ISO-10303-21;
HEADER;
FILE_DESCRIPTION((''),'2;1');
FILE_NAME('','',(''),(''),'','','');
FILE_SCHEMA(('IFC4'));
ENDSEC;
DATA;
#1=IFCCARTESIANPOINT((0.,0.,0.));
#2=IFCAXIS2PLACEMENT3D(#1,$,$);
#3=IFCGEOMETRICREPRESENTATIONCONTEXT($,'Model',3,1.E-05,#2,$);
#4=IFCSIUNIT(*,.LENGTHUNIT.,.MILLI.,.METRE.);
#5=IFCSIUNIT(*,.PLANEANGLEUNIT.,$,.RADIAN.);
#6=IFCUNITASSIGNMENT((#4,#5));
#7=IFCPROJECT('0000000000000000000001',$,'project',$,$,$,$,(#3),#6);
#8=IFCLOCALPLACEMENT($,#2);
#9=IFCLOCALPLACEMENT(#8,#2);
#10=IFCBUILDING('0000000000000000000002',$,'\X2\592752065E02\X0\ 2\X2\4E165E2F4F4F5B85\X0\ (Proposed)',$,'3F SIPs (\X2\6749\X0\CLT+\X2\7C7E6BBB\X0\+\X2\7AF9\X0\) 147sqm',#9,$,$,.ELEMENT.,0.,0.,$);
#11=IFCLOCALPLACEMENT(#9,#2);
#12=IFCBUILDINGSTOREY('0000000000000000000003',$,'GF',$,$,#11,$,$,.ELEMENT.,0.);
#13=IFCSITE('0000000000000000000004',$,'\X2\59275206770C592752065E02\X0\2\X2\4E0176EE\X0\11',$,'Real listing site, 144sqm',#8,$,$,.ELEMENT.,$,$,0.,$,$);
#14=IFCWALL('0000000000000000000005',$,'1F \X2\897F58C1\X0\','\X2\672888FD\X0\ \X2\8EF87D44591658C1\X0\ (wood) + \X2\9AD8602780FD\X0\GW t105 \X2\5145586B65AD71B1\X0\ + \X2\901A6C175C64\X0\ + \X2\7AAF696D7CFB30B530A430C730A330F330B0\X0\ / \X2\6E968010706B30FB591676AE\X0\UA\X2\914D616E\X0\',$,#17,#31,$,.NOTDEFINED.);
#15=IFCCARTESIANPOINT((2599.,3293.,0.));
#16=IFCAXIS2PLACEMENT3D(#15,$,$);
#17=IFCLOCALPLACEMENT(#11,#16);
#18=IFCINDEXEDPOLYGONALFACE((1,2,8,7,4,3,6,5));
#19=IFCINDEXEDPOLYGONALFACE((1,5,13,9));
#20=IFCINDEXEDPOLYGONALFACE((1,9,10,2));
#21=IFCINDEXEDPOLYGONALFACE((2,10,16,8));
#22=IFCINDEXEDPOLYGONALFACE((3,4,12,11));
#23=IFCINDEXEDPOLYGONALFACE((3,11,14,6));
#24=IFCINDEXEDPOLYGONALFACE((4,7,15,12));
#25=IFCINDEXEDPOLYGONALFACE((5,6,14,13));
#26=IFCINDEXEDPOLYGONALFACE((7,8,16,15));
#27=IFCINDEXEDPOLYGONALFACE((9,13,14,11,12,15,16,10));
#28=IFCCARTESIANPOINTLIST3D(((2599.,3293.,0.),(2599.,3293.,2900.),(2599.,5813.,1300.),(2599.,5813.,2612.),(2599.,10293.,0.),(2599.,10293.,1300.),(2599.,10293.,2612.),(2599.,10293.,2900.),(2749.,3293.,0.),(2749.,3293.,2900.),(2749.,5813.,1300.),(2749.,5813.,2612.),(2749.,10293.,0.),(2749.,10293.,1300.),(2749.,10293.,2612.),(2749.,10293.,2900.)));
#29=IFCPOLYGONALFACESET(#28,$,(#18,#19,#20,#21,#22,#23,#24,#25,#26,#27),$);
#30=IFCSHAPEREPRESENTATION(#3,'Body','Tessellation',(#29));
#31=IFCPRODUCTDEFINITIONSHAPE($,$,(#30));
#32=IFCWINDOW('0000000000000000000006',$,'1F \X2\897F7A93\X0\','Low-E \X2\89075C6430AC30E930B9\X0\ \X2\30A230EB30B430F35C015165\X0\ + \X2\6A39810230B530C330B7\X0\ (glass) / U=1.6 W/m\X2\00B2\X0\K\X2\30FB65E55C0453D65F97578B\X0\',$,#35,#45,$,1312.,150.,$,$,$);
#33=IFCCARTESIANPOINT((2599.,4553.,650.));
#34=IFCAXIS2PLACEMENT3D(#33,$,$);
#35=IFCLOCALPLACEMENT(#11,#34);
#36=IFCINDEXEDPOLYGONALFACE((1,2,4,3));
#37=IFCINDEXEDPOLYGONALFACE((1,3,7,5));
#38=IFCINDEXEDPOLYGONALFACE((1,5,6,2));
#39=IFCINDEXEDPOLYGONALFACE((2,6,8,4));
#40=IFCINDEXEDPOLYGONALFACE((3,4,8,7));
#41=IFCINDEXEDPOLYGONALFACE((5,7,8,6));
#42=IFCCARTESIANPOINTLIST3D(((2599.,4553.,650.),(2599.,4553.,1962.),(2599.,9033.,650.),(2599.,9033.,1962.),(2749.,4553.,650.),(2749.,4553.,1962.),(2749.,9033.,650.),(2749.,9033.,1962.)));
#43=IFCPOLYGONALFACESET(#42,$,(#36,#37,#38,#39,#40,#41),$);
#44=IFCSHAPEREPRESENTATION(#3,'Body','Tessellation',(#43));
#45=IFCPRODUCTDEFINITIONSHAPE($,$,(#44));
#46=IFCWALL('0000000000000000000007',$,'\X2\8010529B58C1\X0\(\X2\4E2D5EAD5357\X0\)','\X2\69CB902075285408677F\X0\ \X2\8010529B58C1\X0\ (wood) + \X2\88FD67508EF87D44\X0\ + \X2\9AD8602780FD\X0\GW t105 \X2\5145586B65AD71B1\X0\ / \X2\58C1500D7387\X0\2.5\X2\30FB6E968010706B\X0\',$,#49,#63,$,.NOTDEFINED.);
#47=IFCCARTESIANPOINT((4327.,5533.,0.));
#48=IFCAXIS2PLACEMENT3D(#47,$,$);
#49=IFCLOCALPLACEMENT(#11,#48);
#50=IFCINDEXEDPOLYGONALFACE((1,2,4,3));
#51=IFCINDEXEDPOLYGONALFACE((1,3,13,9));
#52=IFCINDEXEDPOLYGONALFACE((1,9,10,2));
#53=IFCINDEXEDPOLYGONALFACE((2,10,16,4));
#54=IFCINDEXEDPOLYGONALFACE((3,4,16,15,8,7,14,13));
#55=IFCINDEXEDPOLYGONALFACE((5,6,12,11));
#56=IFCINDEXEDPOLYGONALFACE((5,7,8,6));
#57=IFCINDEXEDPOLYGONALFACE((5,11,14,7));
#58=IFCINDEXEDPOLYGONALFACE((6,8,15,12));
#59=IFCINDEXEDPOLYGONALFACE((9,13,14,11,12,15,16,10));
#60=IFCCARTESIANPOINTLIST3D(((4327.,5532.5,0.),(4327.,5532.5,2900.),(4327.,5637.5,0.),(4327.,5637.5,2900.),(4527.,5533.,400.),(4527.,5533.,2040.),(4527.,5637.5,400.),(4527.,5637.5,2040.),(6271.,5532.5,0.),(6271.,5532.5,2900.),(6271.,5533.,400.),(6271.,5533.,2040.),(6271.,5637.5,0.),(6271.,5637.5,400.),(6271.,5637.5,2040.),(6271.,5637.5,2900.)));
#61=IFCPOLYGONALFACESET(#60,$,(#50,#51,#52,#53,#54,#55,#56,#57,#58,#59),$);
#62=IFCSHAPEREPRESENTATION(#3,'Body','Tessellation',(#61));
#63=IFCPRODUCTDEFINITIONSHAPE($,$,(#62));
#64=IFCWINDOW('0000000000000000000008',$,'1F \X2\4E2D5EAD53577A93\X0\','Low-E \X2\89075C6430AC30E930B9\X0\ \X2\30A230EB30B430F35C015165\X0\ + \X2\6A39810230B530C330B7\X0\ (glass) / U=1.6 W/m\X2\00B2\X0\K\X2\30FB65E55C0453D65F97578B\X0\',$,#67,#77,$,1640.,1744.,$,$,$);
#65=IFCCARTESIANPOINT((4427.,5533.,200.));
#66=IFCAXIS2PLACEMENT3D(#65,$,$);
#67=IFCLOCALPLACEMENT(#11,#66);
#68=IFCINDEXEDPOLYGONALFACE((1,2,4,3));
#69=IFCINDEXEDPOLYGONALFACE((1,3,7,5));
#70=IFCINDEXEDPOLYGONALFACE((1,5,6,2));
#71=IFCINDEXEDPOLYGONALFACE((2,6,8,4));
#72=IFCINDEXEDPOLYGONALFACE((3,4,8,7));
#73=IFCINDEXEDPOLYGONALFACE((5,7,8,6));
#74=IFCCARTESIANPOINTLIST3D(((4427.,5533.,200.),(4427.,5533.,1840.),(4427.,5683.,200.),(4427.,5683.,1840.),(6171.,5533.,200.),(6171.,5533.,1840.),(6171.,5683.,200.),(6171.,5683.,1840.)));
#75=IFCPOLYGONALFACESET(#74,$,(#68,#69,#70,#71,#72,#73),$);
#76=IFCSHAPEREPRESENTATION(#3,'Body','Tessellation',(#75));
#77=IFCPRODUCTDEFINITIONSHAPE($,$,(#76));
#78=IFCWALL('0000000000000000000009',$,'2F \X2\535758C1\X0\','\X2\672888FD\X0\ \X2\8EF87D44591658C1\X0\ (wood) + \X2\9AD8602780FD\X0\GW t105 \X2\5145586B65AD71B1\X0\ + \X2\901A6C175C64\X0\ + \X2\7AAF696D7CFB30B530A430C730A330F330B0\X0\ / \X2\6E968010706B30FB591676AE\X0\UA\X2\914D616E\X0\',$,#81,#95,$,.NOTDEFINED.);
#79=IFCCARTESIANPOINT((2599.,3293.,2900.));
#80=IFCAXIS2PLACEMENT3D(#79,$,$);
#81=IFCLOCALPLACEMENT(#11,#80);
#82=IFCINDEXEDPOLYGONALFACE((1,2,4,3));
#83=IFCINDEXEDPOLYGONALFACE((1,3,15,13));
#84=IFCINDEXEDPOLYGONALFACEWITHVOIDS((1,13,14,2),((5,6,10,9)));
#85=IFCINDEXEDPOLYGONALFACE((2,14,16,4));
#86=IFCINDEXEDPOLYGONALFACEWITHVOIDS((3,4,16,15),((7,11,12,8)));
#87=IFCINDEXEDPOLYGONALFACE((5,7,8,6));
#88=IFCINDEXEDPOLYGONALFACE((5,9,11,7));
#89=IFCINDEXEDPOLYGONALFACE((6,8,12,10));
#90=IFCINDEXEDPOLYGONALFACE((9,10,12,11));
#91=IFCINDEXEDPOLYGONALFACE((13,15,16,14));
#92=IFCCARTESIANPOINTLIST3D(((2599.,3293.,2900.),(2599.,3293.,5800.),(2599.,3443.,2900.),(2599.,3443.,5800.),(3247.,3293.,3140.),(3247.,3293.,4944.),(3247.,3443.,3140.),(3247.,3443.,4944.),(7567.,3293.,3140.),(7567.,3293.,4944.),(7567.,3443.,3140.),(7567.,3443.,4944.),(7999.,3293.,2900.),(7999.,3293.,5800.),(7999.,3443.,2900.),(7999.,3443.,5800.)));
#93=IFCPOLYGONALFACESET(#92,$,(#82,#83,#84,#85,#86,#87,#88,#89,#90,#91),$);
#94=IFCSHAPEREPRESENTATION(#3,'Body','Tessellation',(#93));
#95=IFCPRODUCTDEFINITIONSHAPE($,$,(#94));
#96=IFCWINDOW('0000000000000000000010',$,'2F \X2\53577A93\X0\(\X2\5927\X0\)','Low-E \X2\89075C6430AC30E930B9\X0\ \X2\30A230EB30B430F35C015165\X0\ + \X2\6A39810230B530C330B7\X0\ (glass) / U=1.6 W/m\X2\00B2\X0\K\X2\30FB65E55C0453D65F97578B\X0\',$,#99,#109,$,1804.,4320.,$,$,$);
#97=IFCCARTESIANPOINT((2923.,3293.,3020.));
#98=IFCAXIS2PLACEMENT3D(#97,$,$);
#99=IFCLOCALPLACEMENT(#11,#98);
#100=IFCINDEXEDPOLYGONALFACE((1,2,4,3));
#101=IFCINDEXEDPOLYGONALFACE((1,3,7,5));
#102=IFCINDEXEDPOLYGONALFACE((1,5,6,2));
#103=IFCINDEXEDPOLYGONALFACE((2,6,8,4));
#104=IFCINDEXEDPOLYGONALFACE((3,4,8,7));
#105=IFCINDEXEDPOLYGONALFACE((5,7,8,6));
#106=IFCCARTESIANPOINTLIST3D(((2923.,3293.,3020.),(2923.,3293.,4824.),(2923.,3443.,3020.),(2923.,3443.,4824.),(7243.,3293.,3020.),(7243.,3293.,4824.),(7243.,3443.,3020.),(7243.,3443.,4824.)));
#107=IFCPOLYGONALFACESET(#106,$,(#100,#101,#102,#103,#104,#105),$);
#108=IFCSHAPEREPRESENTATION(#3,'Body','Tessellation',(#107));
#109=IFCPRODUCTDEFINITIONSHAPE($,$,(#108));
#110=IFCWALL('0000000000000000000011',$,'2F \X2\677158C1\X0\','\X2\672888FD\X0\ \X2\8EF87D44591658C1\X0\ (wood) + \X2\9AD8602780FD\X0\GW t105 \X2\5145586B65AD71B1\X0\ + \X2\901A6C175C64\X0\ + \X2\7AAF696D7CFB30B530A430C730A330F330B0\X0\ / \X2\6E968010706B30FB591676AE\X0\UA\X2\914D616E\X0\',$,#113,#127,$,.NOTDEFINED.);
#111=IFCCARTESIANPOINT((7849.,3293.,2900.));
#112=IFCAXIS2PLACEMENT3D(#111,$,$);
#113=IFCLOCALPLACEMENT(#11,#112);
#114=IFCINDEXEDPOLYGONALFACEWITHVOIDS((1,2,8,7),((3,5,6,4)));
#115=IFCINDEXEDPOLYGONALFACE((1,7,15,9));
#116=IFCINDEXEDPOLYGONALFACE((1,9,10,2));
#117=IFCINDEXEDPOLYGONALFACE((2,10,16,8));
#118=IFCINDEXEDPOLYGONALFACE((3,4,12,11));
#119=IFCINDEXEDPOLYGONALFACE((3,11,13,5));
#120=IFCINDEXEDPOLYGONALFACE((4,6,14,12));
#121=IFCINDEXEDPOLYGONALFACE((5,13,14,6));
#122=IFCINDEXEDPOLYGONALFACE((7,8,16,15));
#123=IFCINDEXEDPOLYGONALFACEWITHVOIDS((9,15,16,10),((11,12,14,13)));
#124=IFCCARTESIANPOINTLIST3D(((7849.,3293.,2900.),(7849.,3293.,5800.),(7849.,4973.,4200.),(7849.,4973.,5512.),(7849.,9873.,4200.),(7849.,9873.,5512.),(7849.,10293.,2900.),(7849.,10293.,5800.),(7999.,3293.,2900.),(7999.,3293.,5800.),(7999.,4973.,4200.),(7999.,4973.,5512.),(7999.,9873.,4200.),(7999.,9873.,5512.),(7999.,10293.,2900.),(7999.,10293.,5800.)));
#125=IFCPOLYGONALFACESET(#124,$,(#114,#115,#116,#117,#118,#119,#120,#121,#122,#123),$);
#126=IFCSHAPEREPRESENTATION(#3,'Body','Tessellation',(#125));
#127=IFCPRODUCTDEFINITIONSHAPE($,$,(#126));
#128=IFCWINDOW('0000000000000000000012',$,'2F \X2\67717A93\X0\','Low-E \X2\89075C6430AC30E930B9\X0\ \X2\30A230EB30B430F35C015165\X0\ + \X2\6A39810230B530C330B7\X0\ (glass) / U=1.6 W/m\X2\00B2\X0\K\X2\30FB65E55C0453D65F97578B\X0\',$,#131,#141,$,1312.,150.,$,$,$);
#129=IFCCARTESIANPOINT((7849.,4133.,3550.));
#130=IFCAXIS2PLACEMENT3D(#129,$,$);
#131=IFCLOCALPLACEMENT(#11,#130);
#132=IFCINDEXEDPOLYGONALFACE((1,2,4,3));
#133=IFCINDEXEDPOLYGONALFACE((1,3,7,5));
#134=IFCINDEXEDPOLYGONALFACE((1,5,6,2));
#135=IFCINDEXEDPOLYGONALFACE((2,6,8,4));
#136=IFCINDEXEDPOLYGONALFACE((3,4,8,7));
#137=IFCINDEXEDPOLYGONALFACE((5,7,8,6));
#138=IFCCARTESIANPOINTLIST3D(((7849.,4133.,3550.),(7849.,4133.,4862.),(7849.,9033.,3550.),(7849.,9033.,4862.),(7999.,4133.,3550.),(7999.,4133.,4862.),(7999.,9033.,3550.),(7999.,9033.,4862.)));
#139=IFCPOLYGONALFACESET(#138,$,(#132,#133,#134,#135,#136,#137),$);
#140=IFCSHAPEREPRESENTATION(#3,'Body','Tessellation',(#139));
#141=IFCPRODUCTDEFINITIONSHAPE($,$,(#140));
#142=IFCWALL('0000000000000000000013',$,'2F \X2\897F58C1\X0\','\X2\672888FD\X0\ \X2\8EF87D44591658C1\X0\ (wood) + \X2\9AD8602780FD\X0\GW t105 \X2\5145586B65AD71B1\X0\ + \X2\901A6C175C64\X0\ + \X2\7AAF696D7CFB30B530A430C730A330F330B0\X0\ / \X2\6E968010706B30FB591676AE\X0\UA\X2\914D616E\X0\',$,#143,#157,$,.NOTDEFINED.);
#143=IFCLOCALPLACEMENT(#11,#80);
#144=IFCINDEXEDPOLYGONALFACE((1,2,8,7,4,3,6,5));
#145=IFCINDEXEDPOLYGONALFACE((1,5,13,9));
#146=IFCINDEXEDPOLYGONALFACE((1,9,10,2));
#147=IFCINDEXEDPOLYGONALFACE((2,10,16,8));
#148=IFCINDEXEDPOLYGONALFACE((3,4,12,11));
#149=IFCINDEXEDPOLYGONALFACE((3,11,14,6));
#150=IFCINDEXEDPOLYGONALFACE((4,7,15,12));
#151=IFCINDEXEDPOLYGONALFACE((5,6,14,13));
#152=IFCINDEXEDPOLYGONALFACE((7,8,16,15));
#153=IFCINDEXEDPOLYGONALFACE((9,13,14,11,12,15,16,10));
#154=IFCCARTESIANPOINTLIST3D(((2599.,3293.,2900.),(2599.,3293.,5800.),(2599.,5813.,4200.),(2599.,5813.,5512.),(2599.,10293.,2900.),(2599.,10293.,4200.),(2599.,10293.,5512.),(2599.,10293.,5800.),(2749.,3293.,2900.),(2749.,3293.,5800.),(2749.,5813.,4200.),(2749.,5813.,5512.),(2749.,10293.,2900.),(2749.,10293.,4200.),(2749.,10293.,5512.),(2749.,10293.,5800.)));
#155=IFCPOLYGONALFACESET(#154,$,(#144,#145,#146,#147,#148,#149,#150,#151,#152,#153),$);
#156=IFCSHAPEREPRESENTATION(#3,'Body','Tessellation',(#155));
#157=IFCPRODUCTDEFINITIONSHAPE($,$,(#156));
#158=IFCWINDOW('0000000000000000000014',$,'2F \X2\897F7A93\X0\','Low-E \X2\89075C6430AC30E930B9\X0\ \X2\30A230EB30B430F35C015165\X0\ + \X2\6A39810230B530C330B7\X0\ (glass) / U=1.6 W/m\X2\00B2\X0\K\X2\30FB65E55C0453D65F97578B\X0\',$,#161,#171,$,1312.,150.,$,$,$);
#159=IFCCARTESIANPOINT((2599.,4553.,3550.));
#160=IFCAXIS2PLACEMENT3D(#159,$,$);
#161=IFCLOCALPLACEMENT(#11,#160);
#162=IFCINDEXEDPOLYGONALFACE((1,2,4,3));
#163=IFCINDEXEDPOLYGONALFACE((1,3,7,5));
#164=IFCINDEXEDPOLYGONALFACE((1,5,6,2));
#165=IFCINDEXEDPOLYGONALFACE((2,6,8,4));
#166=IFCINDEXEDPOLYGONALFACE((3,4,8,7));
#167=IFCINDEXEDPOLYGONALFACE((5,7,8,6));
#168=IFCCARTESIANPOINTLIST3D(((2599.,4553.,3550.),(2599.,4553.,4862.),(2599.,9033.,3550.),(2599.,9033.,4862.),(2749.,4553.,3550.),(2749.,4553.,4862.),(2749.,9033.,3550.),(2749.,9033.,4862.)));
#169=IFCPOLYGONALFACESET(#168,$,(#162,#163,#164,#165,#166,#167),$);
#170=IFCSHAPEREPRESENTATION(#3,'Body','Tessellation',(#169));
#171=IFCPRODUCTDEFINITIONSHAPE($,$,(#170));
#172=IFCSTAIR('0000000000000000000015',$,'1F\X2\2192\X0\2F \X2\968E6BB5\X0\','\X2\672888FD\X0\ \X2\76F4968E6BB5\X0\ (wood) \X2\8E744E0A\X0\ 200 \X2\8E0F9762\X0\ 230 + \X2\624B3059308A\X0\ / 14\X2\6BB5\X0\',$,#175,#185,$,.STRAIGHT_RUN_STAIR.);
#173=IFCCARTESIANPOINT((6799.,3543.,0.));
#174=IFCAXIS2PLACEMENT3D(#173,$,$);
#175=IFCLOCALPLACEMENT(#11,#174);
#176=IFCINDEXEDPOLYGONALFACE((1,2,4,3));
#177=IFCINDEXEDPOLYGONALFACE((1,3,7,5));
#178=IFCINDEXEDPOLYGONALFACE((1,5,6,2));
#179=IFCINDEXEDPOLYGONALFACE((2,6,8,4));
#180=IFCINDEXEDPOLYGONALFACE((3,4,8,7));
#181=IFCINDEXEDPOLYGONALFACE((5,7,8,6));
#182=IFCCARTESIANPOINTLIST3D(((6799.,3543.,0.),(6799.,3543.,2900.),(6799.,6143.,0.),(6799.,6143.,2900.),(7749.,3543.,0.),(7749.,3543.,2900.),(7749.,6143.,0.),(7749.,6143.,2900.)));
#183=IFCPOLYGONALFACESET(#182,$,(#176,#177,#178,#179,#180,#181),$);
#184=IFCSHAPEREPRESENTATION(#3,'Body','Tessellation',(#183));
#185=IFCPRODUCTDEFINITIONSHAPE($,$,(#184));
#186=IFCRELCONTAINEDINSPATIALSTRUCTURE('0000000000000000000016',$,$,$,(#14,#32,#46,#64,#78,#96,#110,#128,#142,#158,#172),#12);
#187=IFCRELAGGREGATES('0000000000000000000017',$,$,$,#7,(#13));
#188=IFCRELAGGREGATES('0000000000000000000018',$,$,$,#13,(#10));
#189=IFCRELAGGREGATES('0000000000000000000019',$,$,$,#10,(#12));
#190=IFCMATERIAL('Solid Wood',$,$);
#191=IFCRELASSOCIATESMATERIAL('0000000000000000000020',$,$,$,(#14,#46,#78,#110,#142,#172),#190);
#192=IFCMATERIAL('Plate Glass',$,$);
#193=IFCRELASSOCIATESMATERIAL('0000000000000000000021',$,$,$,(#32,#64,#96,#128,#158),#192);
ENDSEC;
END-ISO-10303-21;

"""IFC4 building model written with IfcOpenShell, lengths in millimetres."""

from ifc_helpers import new_model, si_unit, frame, frame_2d, origin, place, context, project, spatial, rectangle, extrude, material, element, fill, save


model = new_model("IFC4")

# Units and contexts
model_context = context("Model", 3, precision=1e-05, world=origin())
ifc_project = project(units=[si_unit("LENGTHUNIT", "METRE", prefix="MILLI"), si_unit("PLANEANGLEUNIT", "RADIAN")], contexts=[model_context])

# Site, building, storey
site_placement = place(None, origin())
site = spatial("IfcSite", under=ifc_project, at=site_placement, Name="大分県大分市2丁目11", ObjectType="Real listing site, 144sqm", CompositionType="ELEMENT", RefElevation=0.0)
building_placement = place(site_placement, origin())
building = spatial("IfcBuilding", under=site, at=building_placement, Name="大分市 2世帯住宅 (Proposed)", ObjectType="3F SIPs (杉CLT+籾殻+竹) 147sqm", CompositionType="ELEMENT", ElevationOfRefHeight=0.0, ElevationOfTerrain=0.0)
storey_placement = place(building_placement, origin())
storey = spatial("IfcBuildingStorey", under=building, at=storey_placement, Name="GF", CompositionType="ELEMENT", Elevation=0.0)

# Shared definitions
ifc_material_1 = material(Name="Solid Wood")

# Shared definitions
ifc_material_2 = material(Name="Plate Glass")

# Walls, openings, windows
wall_1_placement = place(storey_placement, frame((2599.0, 3293.0, 0.0)))
wall_1 = element("IfcWall", 1, at=wall_1_placement, inside=storey, material=ifc_material_1, Name="1F 西壁", Description="木製 軸組外壁 (wood) + 高性能GW t105 充填断熱 + 通気層 + 窯業系サイディング / 準耐火・外皮UA配慮", PredefinedType="NOTDEFINED", context=model_context, shape_type="SweptSolid", body=[
    extrude(rectangle(XDim=150.0, YDim=7000.0, at=frame_2d((75.0, 3500.0))), frame((2599.0, 3293.0, 0.0)), (0.0, 0.0, 1.0), 2900.0),
])
opening_1_placement = place(storey_placement, frame((2599.0, 4553.0, 650.0)))
opening_1 = element("IfcOpeningElement", 2, at=opening_1_placement, cuts=wall_1, PredefinedType="NOTDEFINED", context=model_context, shape_type="SweptSolid", body=[
    extrude(rectangle(XDim=150.0, YDim=4480.0, at=frame_2d((75.0, 2240.0))), frame((2599.0, 4553.0, 650.0)), (0.0, 0.0, 1.0), 1312.0),
])
window_1_placement = place(storey_placement, frame((2599.0, 4553.0, 650.0)))
window_1 = element("IfcWindow", 3, at=window_1_placement, inside=storey, material=ifc_material_2, Name="1F 西窓", Description="Low-E 複層ガラス アルゴン封入 + 樹脂サッシ (glass) / U=1.6 W/m²K・日射取得型", OverallHeight=1312.0, OverallWidth=150.0, context=model_context, shape_type="SweptSolid", body=[
    extrude(rectangle(XDim=150.0, YDim=4480.0, at=frame_2d((75.0, 2240.0))), frame((2599.0, 4553.0, 650.0)), (0.0, 0.0, 1.0), 1312.0),
])
fill(opening_1, window_1)
wall_2_placement = place(storey_placement, frame((4327.0, 5533.0, 0.0)))
wall_2 = element("IfcWall", 4, at=wall_2_placement, inside=storey, material=ifc_material_1, Name="耐力壁(中庭南)", Description="構造用合板 耐力壁 (wood) + 製材軸組 + 高性能GW t105 充填断熱 / 壁倍率2.5・準耐火", PredefinedType="NOTDEFINED", context=model_context, shape_type="SweptSolid", body=[
    extrude(rectangle(XDim=1944.0, YDim=105.0, at=frame_2d((972.0, 52.0))), frame((4327.0, 5533.0, 0.0)), (0.0, 0.0, 1.0), 2900.0),
])
opening_2_placement = place(storey_placement, frame((4427.0, 5533.0, 200.0)))
opening_2 = element("IfcOpeningElement", 5, at=opening_2_placement, cuts=wall_2, PredefinedType="NOTDEFINED", context=model_context, shape_type="SweptSolid", body=[
    extrude(rectangle(XDim=1744.0, YDim=150.0, at=frame_2d((872.0, 75.0))), frame((4427.0, 5533.0, 200.0)), (0.0, 0.0, 1.0), 1640.0),
])
window_2_placement = place(storey_placement, frame((4427.0, 5533.0, 200.0)))
window_2 = element("IfcWindow", 6, at=window_2_placement, inside=storey, material=ifc_material_2, Name="1F 中庭南窓", Description="Low-E 複層ガラス アルゴン封入 + 樹脂サッシ (glass) / U=1.6 W/m²K・日射取得型", OverallHeight=1640.0, OverallWidth=1744.0, context=model_context, shape_type="SweptSolid", body=[
    extrude(rectangle(XDim=1744.0, YDim=150.0, at=frame_2d((872.0, 75.0))), frame((4427.0, 5533.0, 200.0)), (0.0, 0.0, 1.0), 1640.0),
])
fill(opening_2, window_2)
wall_3_placement = place(storey_placement, frame((2599.0, 3293.0, 2900.0)))
wall_3 = element("IfcWall", 7, at=wall_3_placement, inside=storey, material=ifc_material_1, Name="2F 南壁", Description="木製 軸組外壁 (wood) + 高性能GW t105 充填断熱 + 通気層 + 窯業系サイディング / 準耐火・外皮UA配慮", PredefinedType="NOTDEFINED", context=model_context, shape_type="SweptSolid", body=[
    extrude(rectangle(XDim=5400.0, YDim=150.0, at=frame_2d((2700.0, 75.0))), frame((2599.0, 3293.0, 2900.0)), (0.0, 0.0, 1.0), 2900.0),
])
opening_3_placement = place(storey_placement, frame((2923.0, 3293.0, 3020.0)))
opening_3 = element("IfcOpeningElement", 8, at=opening_3_placement, cuts=wall_3, PredefinedType="NOTDEFINED", context=model_context, shape_type="SweptSolid", body=[
    extrude(rectangle(XDim=4320.0, YDim=150.0, at=frame_2d((2160.0, 75.0))), frame((2923.0, 3293.0, 3020.0)), (0.0, 0.0, 1.0), 1804.0),
])
window_3_placement = place(storey_placement, frame((2923.0, 3293.0, 3020.0)))
window_3 = element("IfcWindow", 9, at=window_3_placement, inside=storey, material=ifc_material_2, Name="2F 南窓(大)", Description="Low-E 複層ガラス アルゴン封入 + 樹脂サッシ (glass) / U=1.6 W/m²K・日射取得型", OverallHeight=1804.0, OverallWidth=4320.0, context=model_context, shape_type="SweptSolid", body=[
    extrude(rectangle(XDim=4320.0, YDim=150.0, at=frame_2d((2160.0, 75.0))), frame((2923.0, 3293.0, 3020.0)), (0.0, 0.0, 1.0), 1804.0),
])
fill(opening_3, window_3)
wall_4_placement = place(storey_placement, frame((7849.0, 3293.0, 2900.0)))
wall_4 = element("IfcWall", 10, at=wall_4_placement, inside=storey, material=ifc_material_1, Name="2F 東壁", Description="木製 軸組外壁 (wood) + 高性能GW t105 充填断熱 + 通気層 + 窯業系サイディング / 準耐火・外皮UA配慮", PredefinedType="NOTDEFINED", context=model_context, shape_type="SweptSolid", body=[
    extrude(rectangle(XDim=150.0, YDim=7000.0, at=frame_2d((75.0, 3500.0))), frame((7849.0, 3293.0, 2900.0)), (0.0, 0.0, 1.0), 2900.0),
])
opening_4_placement = place(storey_placement, frame((7849.0, 4133.0, 3550.0)))
opening_4 = element("IfcOpeningElement", 11, at=opening_4_placement, cuts=wall_4, PredefinedType="NOTDEFINED", context=model_context, shape_type="SweptSolid", body=[
    extrude(rectangle(XDim=150.0, YDim=4900.0, at=frame_2d((75.0, 2450.0))), frame((7849.0, 4133.0, 3550.0)), (0.0, 0.0, 1.0), 1312.0),
])
window_4_placement = place(storey_placement, frame((7849.0, 4133.0, 3550.0)))
window_4 = element("IfcWindow", 12, at=window_4_placement, inside=storey, material=ifc_material_2, Name="2F 東窓", Description="Low-E 複層ガラス アルゴン封入 + 樹脂サッシ (glass) / U=1.6 W/m²K・日射取得型", OverallHeight=1312.0, OverallWidth=150.0, context=model_context, shape_type="SweptSolid", body=[
    extrude(rectangle(XDim=150.0, YDim=4900.0, at=frame_2d((75.0, 2450.0))), frame((7849.0, 4133.0, 3550.0)), (0.0, 0.0, 1.0), 1312.0),
])
fill(opening_4, window_4)
wall_5_placement = place(storey_placement, frame((2599.0, 3293.0, 2900.0)))
wall_5 = element("IfcWall", 13, at=wall_5_placement, inside=storey, material=ifc_material_1, Name="2F 西壁", Description="木製 軸組外壁 (wood) + 高性能GW t105 充填断熱 + 通気層 + 窯業系サイディング / 準耐火・外皮UA配慮", PredefinedType="NOTDEFINED", context=model_context, shape_type="SweptSolid", body=[
    extrude(rectangle(XDim=150.0, YDim=7000.0, at=frame_2d((75.0, 3500.0))), frame((2599.0, 3293.0, 2900.0)), (0.0, 0.0, 1.0), 2900.0),
])
opening_5_placement = place(storey_placement, frame((2599.0, 4553.0, 3550.0)))
opening_5 = element("IfcOpeningElement", 14, at=opening_5_placement, cuts=wall_5, PredefinedType="NOTDEFINED", context=model_context, shape_type="SweptSolid", body=[
    extrude(rectangle(XDim=150.0, YDim=4480.0, at=frame_2d((75.0, 2240.0))), frame((2599.0, 4553.0, 3550.0)), (0.0, 0.0, 1.0), 1312.0),
])
window_5_placement = place(storey_placement, frame((2599.0, 4553.0, 3550.0)))
window_5 = element("IfcWindow", 15, at=window_5_placement, inside=storey, material=ifc_material_2, Name="2F 西窓", Description="Low-E 複層ガラス アルゴン封入 + 樹脂サッシ (glass) / U=1.6 W/m²K・日射取得型", OverallHeight=1312.0, OverallWidth=150.0, context=model_context, shape_type="SweptSolid", body=[
    extrude(rectangle(XDim=150.0, YDim=4480.0, at=frame_2d((75.0, 2240.0))), frame((2599.0, 4553.0, 3550.0)), (0.0, 0.0, 1.0), 1312.0),
])
fill(opening_5, window_5)

# Stair
stair_1_placement = place(storey_placement, frame((6799.0, 3543.0, 0.0)))
element("IfcStair", 16, at=stair_1_placement, inside=storey, material=ifc_material_1, Name="1F→2F 階段", Description="木製 直階段 (wood) 蹴上 200 踏面 230 + 手すり / 14段", PredefinedType="STRAIGHT_RUN_STAIR", context=model_context, shape_type="SweptSolid", body=[
    extrude(rectangle(XDim=950.0, YDim=2600.0, at=frame_2d((475.0, 1300.0))), frame((6799.0, 3543.0, 0.0)), (0.0, 0.0, 1.0), 2900.0),
])

save(model, "model.ifc")
